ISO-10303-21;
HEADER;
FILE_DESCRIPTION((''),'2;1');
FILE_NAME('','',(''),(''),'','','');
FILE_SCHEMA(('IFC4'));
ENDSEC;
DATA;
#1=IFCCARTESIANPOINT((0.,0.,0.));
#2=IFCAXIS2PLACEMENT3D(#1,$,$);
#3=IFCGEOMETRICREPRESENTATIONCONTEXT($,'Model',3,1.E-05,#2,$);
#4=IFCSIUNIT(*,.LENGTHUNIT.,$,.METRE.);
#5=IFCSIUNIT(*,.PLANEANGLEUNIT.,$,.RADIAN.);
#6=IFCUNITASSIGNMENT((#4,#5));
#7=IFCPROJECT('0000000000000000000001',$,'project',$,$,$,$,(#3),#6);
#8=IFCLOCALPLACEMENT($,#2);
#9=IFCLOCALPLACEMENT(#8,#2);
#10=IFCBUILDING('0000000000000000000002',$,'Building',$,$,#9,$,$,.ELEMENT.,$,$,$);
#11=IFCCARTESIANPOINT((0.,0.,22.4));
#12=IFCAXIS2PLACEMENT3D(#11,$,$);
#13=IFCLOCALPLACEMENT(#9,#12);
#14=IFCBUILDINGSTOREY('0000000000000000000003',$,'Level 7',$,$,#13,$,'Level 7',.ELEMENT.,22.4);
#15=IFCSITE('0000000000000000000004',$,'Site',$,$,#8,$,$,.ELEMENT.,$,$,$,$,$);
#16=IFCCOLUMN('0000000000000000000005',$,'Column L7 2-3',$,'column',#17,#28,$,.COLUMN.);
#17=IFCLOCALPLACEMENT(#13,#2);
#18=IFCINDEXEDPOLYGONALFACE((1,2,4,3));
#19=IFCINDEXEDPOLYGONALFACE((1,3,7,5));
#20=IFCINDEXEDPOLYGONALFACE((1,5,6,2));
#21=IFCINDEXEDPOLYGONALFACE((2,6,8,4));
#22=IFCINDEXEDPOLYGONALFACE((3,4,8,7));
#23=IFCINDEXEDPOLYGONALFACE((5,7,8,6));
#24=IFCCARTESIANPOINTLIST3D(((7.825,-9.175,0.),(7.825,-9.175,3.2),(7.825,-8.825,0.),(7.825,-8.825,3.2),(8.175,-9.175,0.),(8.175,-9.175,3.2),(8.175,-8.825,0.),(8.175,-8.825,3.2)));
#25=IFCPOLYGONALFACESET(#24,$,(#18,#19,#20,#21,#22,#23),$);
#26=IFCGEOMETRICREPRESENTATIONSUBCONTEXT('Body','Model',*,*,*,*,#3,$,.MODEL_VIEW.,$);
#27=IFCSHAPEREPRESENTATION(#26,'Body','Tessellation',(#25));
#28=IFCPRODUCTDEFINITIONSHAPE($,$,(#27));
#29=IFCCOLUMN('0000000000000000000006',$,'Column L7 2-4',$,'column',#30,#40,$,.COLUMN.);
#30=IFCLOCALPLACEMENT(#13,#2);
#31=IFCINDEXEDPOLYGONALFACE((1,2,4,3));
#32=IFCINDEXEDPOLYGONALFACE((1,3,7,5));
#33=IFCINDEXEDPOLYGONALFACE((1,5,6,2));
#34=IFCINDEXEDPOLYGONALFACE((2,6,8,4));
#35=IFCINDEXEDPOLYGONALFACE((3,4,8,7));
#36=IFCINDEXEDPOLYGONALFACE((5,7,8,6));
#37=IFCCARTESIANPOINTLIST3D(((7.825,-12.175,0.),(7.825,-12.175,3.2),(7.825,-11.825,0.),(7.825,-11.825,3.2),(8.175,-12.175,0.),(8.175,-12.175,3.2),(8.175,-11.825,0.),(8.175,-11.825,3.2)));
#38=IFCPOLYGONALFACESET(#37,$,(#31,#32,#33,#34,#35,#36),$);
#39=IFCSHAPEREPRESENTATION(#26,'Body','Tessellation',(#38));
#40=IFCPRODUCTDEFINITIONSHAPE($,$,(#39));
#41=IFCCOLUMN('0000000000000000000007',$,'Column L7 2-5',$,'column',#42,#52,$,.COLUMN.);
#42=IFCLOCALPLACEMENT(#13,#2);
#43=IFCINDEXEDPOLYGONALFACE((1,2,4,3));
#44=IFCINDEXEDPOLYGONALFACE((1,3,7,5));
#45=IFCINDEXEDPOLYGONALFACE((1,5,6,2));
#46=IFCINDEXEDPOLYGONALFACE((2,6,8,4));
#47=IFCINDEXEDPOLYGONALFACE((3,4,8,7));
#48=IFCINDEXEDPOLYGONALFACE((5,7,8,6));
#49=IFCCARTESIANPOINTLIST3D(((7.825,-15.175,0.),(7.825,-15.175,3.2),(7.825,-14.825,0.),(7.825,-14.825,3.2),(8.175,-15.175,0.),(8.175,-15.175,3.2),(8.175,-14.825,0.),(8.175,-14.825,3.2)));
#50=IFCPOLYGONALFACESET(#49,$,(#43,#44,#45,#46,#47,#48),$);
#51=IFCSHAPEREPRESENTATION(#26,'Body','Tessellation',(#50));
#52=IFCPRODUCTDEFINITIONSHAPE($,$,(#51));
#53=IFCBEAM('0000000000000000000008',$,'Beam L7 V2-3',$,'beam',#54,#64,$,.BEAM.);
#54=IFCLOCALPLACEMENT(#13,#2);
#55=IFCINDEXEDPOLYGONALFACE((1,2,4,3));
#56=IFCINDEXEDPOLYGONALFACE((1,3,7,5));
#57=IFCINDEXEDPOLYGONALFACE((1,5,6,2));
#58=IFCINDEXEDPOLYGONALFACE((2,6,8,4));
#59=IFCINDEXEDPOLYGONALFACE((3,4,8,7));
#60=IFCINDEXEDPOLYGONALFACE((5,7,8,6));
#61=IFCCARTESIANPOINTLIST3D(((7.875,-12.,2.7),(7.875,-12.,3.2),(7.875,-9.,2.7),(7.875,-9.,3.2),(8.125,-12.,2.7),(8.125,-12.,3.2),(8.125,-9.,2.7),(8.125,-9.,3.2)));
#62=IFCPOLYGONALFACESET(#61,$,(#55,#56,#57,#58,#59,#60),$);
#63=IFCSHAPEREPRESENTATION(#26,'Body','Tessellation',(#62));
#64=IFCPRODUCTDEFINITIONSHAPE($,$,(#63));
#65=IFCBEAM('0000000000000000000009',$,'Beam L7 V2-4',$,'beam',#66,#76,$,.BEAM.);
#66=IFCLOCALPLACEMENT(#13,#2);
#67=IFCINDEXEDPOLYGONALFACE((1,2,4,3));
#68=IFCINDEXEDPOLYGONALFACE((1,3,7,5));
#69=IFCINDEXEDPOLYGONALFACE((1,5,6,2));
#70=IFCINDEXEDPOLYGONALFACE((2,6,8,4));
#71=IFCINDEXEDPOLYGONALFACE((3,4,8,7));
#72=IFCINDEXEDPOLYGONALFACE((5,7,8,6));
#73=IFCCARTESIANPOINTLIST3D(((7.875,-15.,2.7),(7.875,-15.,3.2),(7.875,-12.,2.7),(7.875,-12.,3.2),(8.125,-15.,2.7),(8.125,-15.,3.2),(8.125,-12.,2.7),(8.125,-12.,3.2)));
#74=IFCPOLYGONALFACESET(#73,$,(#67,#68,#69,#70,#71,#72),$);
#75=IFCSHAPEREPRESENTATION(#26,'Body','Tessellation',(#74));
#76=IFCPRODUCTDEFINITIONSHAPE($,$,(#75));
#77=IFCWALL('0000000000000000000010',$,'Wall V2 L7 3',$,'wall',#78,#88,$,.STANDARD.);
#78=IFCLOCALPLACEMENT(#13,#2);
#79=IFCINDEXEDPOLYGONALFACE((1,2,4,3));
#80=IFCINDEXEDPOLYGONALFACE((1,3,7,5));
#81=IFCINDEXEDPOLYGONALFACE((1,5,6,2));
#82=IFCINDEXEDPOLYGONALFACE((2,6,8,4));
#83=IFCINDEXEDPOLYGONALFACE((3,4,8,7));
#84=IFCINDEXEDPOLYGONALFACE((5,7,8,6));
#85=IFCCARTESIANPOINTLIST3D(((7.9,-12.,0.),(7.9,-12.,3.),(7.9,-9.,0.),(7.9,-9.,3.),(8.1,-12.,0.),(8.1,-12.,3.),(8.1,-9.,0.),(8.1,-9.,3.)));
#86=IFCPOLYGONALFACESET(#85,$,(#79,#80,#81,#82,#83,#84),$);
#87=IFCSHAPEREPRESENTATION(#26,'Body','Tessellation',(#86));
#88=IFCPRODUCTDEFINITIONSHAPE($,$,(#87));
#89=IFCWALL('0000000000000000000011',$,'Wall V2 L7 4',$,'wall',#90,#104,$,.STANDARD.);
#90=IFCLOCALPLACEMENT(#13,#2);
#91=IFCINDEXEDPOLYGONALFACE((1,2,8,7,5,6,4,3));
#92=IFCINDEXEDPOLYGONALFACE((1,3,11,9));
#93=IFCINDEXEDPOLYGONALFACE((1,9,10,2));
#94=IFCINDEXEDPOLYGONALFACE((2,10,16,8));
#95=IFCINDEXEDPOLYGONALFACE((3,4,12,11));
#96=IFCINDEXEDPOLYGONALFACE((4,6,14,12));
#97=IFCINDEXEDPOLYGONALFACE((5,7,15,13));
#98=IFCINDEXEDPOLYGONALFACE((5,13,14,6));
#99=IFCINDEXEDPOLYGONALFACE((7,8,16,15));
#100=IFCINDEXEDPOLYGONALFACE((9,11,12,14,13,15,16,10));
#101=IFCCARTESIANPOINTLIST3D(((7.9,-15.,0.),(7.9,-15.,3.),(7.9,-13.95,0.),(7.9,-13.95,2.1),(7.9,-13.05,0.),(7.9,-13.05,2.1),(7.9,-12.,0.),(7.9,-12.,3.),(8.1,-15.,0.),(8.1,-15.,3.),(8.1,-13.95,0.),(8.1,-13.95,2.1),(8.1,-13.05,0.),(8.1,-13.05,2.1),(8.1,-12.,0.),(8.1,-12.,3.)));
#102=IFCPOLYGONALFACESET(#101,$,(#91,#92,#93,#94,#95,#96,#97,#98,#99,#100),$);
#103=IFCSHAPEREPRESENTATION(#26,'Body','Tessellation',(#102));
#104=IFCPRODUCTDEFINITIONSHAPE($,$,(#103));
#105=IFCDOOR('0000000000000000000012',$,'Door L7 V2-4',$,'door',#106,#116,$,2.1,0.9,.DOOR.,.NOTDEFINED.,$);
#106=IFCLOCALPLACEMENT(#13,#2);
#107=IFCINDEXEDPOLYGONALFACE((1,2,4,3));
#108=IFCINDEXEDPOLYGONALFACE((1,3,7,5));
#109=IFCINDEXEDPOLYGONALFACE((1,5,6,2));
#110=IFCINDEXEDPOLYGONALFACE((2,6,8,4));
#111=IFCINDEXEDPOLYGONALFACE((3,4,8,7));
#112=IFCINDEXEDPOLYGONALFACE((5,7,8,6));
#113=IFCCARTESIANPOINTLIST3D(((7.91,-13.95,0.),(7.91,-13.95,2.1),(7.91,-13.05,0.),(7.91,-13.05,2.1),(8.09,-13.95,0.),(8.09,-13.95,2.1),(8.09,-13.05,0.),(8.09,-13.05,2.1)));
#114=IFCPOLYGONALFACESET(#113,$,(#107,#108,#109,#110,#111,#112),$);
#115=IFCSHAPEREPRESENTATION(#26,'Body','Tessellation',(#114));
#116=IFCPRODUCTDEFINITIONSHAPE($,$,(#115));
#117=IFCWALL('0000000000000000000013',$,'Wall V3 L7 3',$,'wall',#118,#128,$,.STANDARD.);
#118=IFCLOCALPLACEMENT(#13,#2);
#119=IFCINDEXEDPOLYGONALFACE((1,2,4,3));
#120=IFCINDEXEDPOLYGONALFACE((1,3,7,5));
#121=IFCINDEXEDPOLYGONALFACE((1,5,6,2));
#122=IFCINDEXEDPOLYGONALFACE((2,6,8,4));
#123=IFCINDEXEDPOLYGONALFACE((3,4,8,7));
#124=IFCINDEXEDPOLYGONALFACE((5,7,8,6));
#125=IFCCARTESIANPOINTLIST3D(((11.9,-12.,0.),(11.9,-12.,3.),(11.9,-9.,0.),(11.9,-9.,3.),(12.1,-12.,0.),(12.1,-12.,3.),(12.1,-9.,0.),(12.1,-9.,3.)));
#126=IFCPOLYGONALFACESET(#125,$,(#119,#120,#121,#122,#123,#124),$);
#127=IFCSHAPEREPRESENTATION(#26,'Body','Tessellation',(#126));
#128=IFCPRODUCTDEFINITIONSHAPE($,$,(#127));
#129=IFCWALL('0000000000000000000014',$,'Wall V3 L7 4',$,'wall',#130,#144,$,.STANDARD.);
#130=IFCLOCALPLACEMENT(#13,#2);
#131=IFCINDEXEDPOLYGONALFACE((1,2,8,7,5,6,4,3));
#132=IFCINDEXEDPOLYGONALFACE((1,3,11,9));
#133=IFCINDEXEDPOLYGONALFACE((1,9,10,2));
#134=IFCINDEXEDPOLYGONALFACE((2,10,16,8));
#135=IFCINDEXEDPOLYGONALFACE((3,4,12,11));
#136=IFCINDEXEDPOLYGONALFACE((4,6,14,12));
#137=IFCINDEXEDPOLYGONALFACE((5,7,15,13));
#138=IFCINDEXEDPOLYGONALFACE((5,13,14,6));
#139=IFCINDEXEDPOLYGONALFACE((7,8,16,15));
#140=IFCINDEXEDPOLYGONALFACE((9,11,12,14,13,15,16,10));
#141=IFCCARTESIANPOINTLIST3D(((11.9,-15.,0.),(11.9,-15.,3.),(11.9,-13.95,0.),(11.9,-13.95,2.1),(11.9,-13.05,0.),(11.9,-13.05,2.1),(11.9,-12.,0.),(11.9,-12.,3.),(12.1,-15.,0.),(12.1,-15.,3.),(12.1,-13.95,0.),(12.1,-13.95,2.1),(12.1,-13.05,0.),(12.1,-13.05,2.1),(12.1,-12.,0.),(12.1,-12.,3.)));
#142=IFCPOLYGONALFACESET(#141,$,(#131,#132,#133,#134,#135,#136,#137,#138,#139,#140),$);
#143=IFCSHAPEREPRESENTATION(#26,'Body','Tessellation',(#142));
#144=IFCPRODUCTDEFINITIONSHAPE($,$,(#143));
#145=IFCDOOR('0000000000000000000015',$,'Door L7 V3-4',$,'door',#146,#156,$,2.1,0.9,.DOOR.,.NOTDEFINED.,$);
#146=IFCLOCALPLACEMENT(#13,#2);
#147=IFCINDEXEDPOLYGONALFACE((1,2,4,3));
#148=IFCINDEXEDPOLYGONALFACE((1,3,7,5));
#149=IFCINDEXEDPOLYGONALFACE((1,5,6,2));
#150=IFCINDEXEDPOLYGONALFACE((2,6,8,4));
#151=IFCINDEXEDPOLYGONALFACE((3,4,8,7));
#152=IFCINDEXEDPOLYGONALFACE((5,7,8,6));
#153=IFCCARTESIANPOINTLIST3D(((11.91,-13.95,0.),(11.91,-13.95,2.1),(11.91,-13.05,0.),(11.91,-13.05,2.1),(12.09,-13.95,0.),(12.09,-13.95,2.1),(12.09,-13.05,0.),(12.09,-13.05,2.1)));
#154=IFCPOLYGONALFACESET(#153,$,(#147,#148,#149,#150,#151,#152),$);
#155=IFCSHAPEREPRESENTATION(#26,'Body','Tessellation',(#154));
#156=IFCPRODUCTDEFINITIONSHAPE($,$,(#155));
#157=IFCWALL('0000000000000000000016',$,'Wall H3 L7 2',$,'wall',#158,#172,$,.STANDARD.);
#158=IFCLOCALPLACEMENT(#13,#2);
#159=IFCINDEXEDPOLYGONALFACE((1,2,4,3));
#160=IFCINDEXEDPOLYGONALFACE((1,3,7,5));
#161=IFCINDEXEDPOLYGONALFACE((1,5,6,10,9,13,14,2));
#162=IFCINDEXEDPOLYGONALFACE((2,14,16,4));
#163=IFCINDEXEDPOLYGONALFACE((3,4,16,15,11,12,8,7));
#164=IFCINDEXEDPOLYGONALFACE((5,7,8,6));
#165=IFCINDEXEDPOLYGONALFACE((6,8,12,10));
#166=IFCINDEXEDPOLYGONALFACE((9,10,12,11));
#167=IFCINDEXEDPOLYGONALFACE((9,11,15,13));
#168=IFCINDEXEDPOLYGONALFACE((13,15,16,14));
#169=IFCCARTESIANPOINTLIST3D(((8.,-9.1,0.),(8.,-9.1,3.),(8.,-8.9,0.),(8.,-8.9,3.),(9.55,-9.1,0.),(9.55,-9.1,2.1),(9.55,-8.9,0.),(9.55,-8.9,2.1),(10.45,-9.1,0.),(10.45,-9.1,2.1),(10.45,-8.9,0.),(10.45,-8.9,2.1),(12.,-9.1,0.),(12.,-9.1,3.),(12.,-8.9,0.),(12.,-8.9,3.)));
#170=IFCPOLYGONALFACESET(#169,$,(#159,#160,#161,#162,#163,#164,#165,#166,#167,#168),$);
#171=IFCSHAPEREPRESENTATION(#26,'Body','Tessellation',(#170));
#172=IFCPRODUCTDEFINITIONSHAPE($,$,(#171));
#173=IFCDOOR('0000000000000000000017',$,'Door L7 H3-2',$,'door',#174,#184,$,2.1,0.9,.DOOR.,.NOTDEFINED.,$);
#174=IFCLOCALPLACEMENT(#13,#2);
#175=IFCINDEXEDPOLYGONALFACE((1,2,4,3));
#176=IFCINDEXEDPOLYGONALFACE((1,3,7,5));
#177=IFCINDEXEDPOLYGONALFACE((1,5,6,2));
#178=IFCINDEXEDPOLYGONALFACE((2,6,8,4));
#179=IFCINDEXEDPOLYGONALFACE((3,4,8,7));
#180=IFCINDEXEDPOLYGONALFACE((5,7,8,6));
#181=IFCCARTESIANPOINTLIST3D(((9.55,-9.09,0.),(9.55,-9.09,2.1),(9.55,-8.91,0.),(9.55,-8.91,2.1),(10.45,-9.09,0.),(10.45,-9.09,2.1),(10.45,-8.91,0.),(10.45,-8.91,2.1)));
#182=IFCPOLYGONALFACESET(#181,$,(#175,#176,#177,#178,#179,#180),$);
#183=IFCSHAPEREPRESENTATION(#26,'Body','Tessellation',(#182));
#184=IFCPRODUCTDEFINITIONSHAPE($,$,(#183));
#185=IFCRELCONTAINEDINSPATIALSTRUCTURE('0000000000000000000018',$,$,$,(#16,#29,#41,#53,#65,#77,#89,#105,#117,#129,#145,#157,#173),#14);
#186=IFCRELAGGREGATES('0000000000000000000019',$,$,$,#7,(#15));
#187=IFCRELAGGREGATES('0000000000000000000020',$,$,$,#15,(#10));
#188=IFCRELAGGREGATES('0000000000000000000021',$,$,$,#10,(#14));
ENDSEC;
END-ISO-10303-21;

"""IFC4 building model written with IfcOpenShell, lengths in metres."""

from ifc_helpers import new_model, si_unit, frame, frame_2d, origin, origin_2d, place, context, subcontext, project, spatial, rectangle, extrude, element, fill, save


model = new_model("IFC4")

# Units and contexts
model_context = context("Model", 3, precision=1e-05, world=origin())
body_context = subcontext(model_context, "Body", "Model", "MODEL_VIEW")
ifc_project = project(units=[si_unit("LENGTHUNIT", "METRE"), si_unit("PLANEANGLEUNIT", "RADIAN")], contexts=[model_context])

# Site, building, storey
site_placement = place(None, origin())
site = spatial("IfcSite", under=ifc_project, at=site_placement, Name="Site", CompositionType="ELEMENT")
building_placement = place(site_placement, origin())
building = spatial("IfcBuilding", under=site, at=building_placement, Name="Building", CompositionType="ELEMENT")
storey_placement = place(building_placement, frame((0.0, 0.0, 22.4)))
storey = spatial("IfcBuildingStorey", under=building, at=storey_placement, Name="Level 7", LongName="Level 7", CompositionType="ELEMENT", Elevation=22.4)

# Columns
for number, where, name in (
    (1, (8.0, -9.0, 0.0), "Column L7 2-3"),
    (2, (8.0, -12.0, 0.0), "Column L7 2-4"),
    (3, (8.0, -15.0, 0.0), "Column L7 2-5"),
):
    element("IfcColumn", number, at=place(storey_placement, frame(where)), inside=storey, Name=name, ObjectType="column", PredefinedType="COLUMN", context=body_context, shape_type="SweptSolid", body=[
        extrude(rectangle(XDim=0.35, YDim=0.35, at=origin_2d()), origin(), (0.0, 0.0, 1.0), 3.2),
    ])

# Beams
for number, where, z_axis, x_axis, name in (
    (4, (8.0, -9.0, 2.95), (0.0, -1.0, 0.0), (0.0, 0.0, 1.0), "Beam L7 V2-3"),
    (5, (8.0, -12.0, 2.95), (0.0, -1.0, 0.0), (0.0, 0.0, 1.0), "Beam L7 V2-4"),
):
    element("IfcBeam", number, at=place(storey_placement, frame(where, z_axis=z_axis, x_axis=x_axis)), inside=storey, Name=name, ObjectType="beam", PredefinedType="BEAM", context=body_context, shape_type="SweptSolid", body=[
        extrude(rectangle(XDim=0.5, YDim=0.25, at=origin_2d()), origin(), (0.0, 0.0, 1.0), 3.0),
    ])

# Wall
wall_1_placement = place(storey_placement, frame((8.0, -9.0, 0.0), z_axis=(0.0, 0.0, 1.0), x_axis=(0.0, -1.0, 0.0)))
element("IfcWall", 6, at=wall_1_placement, inside=storey, Name="Wall V2 L7 3", ObjectType="wall", PredefinedType="STANDARD", context=body_context, shape_type="SweptSolid", body=[
    extrude(rectangle(XDim=3.0, YDim=0.2, at=frame_2d((1.5, 0.0))), origin(), (0.0, 0.0, 1.0), 3.0),
])

# Wall, opening, door
wall_2_placement = place(storey_placement, frame((8.0, -12.0, 0.0), z_axis=(0.0, 0.0, 1.0), x_axis=(0.0, -1.0, 0.0)))
wall_2 = element("IfcWall", 7, at=wall_2_placement, inside=storey, Name="Wall V2 L7 4", ObjectType="wall", PredefinedType="STANDARD", context=body_context, shape_type="SweptSolid", body=[
    extrude(rectangle(XDim=3.0, YDim=0.2, at=frame_2d((1.5, 0.0))), origin(), (0.0, 0.0, 1.0), 3.0),
])
opening_1_placement = place(storey_placement, frame((8.0, -13.5, 0.0), z_axis=(0.0, 0.0, 1.0), x_axis=(0.0, -1.0, 0.0)))
opening_1 = element("IfcOpeningElement", 8, at=opening_1_placement, cuts=wall_2, ObjectType="Opening", PredefinedType="OPENING", context=body_context, shape_type="SweptSolid", body=[
    extrude(rectangle(XDim=0.9, YDim=0.22, at=origin_2d()), origin(), (0.0, 0.0, 1.0), 2.1),
])
door_1_placement = place(storey_placement, frame((8.0, -13.5, 0.0), z_axis=(0.0, 0.0, 1.0), x_axis=(0.0, -1.0, 0.0)))
door_1 = element("IfcDoor", 9, at=door_1_placement, inside=storey, Name="Door L7 V2-4", ObjectType="door", OperationType="NOTDEFINED", OverallHeight=2.1, OverallWidth=0.9, PredefinedType="DOOR", context=body_context, shape_type="SweptSolid", body=[
    extrude(rectangle(XDim=0.9, YDim=0.18, at=origin_2d()), origin(), (0.0, 0.0, 1.0), 2.1),
])
fill(opening_1, door_1)

# Wall
wall_3_placement = place(storey_placement, frame((12.0, -9.0, 0.0), z_axis=(0.0, 0.0, 1.0), x_axis=(0.0, -1.0, 0.0)))
element("IfcWall", 10, at=wall_3_placement, inside=storey, Name="Wall V3 L7 3", ObjectType="wall", PredefinedType="STANDARD", context=body_context, shape_type="SweptSolid", body=[
    extrude(rectangle(XDim=3.0, YDim=0.2, at=frame_2d((1.5, 0.0))), origin(), (0.0, 0.0, 1.0), 3.0),
])

# Walls, openings, doors
wall_4_placement = place(storey_placement, frame((12.0, -12.0, 0.0), z_axis=(0.0, 0.0, 1.0), x_axis=(0.0, -1.0, 0.0)))
wall_4 = element("IfcWall", 11, at=wall_4_placement, inside=storey, Name="Wall V3 L7 4", ObjectType="wall", PredefinedType="STANDARD", context=body_context, shape_type="SweptSolid", body=[
    extrude(rectangle(XDim=3.0, YDim=0.2, at=frame_2d((1.5, 0.0))), origin(), (0.0, 0.0, 1.0), 3.0),
])
opening_2_placement = place(storey_placement, frame((12.0, -13.5, 0.0), z_axis=(0.0, 0.0, 1.0), x_axis=(0.0, -1.0, 0.0)))
opening_2 = element("IfcOpeningElement", 12, at=opening_2_placement, cuts=wall_4, ObjectType="Opening", PredefinedType="OPENING", context=body_context, shape_type="SweptSolid", body=[
    extrude(rectangle(XDim=0.9, YDim=0.22, at=origin_2d()), origin(), (0.0, 0.0, 1.0), 2.1),
])
door_2_placement = place(storey_placement, frame((12.0, -13.5, 0.0), z_axis=(0.0, 0.0, 1.0), x_axis=(0.0, -1.0, 0.0)))
door_2 = element("IfcDoor", 13, at=door_2_placement, inside=storey, Name="Door L7 V3-4", ObjectType="door", OperationType="NOTDEFINED", OverallHeight=2.1, OverallWidth=0.9, PredefinedType="DOOR", context=body_context, shape_type="SweptSolid", body=[
    extrude(rectangle(XDim=0.9, YDim=0.18, at=origin_2d()), origin(), (0.0, 0.0, 1.0), 2.1),
])
fill(opening_2, door_2)
wall_5_placement = place(storey_placement, frame((8.0, -9.0, 0.0), z_axis=(0.0, 0.0, 1.0), x_axis=(1.0, 0.0, 0.0)))
wall_5 = element("IfcWall", 14, at=wall_5_placement, inside=storey, Name="Wall H3 L7 2", ObjectType="wall", PredefinedType="STANDARD", context=body_context, shape_type="SweptSolid", body=[
    extrude(rectangle(XDim=4.0, YDim=0.2, at=frame_2d((2.0, 0.0))), origin(), (0.0, 0.0, 1.0), 3.0),
])
opening_3_placement = place(storey_placement, frame((10.0, -9.0, 0.0), z_axis=(0.0, 0.0, 1.0), x_axis=(1.0, 0.0, 0.0)))
opening_3 = element("IfcOpeningElement", 15, at=opening_3_placement, cuts=wall_5, ObjectType="Opening", PredefinedType="OPENING", context=body_context, shape_type="SweptSolid", body=[
    extrude(rectangle(XDim=0.9, YDim=0.22, at=origin_2d()), origin(), (0.0, 0.0, 1.0), 2.1),
])
door_3_placement = place(storey_placement, frame((10.0, -9.0, 0.0), z_axis=(0.0, 0.0, 1.0), x_axis=(1.0, 0.0, 0.0)))
door_3 = element("IfcDoor", 16, at=door_3_placement, inside=storey, Name="Door L7 H3-2", ObjectType="door", OperationType="NOTDEFINED", OverallHeight=2.1, OverallWidth=0.9, PredefinedType="DOOR", context=body_context, shape_type="SweptSolid", body=[
    extrude(rectangle(XDim=0.9, YDim=0.18, at=origin_2d()), origin(), (0.0, 0.0, 1.0), 2.1),
])
fill(opening_3, door_3)

save(model, "model.ifc")
